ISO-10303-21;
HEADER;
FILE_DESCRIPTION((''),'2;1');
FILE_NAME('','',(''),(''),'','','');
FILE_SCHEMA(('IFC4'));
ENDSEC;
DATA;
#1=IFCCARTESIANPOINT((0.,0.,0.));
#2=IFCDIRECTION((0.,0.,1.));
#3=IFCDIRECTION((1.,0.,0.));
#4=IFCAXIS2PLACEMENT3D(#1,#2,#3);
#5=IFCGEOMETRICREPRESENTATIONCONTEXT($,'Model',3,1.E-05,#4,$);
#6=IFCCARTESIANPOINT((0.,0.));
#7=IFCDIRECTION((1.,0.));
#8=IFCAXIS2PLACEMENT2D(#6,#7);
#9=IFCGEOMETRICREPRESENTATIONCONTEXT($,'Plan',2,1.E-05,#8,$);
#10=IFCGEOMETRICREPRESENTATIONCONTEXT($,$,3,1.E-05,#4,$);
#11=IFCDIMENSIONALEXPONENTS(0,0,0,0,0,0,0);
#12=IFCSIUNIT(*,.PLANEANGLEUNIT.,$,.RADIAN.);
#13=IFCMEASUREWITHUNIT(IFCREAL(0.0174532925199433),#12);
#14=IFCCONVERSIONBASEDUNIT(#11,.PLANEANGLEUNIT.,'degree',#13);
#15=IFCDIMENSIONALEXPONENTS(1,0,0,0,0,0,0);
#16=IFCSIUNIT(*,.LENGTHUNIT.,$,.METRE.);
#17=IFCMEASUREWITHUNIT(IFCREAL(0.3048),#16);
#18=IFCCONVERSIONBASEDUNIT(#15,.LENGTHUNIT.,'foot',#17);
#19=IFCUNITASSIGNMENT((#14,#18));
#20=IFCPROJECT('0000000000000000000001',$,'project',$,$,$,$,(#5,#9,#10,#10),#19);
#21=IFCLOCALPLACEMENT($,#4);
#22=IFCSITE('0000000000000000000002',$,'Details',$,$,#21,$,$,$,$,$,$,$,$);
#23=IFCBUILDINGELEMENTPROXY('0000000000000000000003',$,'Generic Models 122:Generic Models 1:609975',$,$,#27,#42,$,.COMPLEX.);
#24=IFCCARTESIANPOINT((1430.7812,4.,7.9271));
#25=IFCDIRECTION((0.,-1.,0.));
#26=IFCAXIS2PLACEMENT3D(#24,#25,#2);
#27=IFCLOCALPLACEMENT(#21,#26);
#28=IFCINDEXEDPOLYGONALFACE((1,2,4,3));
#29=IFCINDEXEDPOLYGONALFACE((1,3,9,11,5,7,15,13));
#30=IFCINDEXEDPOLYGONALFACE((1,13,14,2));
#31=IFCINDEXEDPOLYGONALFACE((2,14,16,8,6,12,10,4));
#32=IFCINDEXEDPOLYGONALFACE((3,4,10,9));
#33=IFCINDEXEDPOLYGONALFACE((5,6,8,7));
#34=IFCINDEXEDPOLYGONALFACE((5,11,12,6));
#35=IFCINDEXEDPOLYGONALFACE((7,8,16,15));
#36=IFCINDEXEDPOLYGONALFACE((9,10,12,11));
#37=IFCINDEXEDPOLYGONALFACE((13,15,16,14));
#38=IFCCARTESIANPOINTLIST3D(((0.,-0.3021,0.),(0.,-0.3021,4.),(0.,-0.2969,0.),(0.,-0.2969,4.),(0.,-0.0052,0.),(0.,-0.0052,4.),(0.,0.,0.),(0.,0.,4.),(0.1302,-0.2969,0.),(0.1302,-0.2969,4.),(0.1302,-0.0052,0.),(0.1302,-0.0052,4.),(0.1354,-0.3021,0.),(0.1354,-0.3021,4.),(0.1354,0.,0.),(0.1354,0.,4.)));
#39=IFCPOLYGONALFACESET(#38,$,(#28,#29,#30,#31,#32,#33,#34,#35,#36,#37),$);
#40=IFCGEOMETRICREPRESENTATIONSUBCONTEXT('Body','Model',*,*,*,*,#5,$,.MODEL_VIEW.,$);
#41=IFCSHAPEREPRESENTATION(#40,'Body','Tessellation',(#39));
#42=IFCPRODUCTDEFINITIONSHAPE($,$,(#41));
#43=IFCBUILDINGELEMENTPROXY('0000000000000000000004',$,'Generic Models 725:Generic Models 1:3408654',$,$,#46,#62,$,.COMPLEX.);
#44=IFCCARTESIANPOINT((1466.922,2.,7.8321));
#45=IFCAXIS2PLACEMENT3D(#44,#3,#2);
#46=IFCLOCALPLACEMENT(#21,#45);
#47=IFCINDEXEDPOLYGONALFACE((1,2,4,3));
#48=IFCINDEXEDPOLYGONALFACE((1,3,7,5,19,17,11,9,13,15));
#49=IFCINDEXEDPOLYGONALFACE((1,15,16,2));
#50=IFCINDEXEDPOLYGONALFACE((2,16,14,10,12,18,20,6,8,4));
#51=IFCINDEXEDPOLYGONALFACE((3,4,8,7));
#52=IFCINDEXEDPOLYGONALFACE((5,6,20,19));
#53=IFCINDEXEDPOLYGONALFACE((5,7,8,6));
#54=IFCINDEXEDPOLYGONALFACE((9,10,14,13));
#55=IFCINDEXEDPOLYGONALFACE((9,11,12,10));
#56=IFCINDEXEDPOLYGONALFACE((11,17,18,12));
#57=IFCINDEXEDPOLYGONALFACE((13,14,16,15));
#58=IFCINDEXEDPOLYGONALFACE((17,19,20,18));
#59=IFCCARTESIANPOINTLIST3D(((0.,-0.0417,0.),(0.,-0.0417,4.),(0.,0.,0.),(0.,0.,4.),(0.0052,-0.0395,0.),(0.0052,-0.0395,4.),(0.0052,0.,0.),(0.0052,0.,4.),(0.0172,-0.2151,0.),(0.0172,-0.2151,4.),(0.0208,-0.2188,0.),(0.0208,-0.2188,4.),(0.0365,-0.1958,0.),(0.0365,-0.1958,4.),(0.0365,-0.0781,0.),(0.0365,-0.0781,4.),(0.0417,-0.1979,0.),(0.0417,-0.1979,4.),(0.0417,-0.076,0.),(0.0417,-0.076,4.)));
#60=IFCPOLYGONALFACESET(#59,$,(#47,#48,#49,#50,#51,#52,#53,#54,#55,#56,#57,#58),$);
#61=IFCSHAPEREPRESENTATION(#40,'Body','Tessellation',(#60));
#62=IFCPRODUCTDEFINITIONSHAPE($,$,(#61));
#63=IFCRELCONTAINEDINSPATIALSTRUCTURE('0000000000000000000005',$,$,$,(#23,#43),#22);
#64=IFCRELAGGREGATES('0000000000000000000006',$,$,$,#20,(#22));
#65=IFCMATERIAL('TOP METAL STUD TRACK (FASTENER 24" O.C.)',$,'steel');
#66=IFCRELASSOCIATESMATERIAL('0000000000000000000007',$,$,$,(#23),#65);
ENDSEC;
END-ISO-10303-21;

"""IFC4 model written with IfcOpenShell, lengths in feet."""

from ifc_helpers import new_model, entity, si_unit, converted_unit, frame, origin_with_axes, origin_2d_with_axis, place, context, subcontext, project, spatial, line, indexed_curve, outline, extrude, material, element, save


model = new_model("IFC4")

# Units and contexts
model_context = context("Model", 3, precision=1e-05, world=origin_with_axes())
plan_context = context("Plan", 2, precision=1e-05, world=origin_2d_with_axis())
context_of_model = context(None, 3, precision=1e-05, world=origin_with_axes())
body_context = subcontext(model_context, "Body", "Model", "MODEL_VIEW")
ifc_project = project(units=[converted_unit("PLANEANGLEUNIT", "degree", entity("IfcReal", 0.0174532925199433), si_unit("PLANEANGLEUNIT", "RADIAN"), dimensions=[0, 0, 0, 0, 0, 0, 0]), converted_unit("LENGTHUNIT", "foot", entity("IfcReal", 0.3048), si_unit("LENGTHUNIT", "METRE"), dimensions=[1, 0, 0, 0, 0, 0, 0])], contexts=[model_context, plan_context, context_of_model, context_of_model])

# Site
site_placement = place(None, origin_with_axes())
site = spatial("IfcSite", under=ifc_project, at=site_placement, Name="Details")

# Building element proxies
ifc_material_1 = material(Name="TOP METAL STUD TRACK (FASTENER 24\" O.C.)", Category="steel")
proxy_1_placement = place(site_placement, frame((1430.7812, 4.0, 7.9271), z_axis=(0.0, -1.0, 0.0), x_axis=(0.0, 0.0, 1.0)))
element("IfcBuildingElementProxy", 1, at=proxy_1_placement, inside=site, material=ifc_material_1, Name="Generic Models 122:Generic Models 1:609975", PredefinedType="COMPLEX", context=body_context, shape_type="SweptSolid", body=[
    extrude(outline(indexed_curve([(-0.069, -0.151), (0.0664, -0.151), (0.0664, -0.1458), (-0.0638, -0.1458), (-0.0638, 0.1458), (0.0664, 0.1458), (0.0664, 0.151), (-0.069, 0.151)], segments=[line(5, 6), line(6, 7), line(7, 8), line(8, 1), line(1, 2), line(2, 3), line(3, 4), line(4, 5)], self_intersect=False)), frame((0.0664, -0.151, 0.0), z_axis=(0.0, 0.0, -1.0), x_axis=(-1.0, 0.0, 0.0)), (0.0, 0.0, -1.0), 4.0),
])
proxy_2_placement = place(site_placement, frame((1466.922, 2.0, 7.8321), z_axis=(1.0, 0.0, 0.0), x_axis=(0.0, 0.0, 1.0)))
element("IfcBuildingElementProxy", 2, at=proxy_2_placement, inside=site, Name="Generic Models 725:Generic Models 1:3408654", PredefinedType="COMPLEX", context=body_context, shape_type="SweptSolid", body=[
    extrude(outline(indexed_curve([(0.0684, -0.0024), (0.1072, 0.0051), (0.1082, 0.0), (0.0673, -0.0079), (0.0246, 0.021), (-0.0909, -0.0012), (-0.1062, -0.0238), (-0.1105, -0.0209), (-0.094, 0.0035), (0.0258, 0.0266)], segments=[line(6, 5), line(5, 4), line(4, 3), line(3, 2), line(2, 1), line(1, 10), line(10, 9), line(9, 8), line(8, 7), line(7, 6)], self_intersect=False)), frame((0.0205, -0.1063, 0.0), z_axis=(0.0, 0.0, -1.0), x_axis=(-0.189091, 0.98196, 0.0)), (0.0, 0.0, -1.0), 4.0),
])

save(model, "model.ifc")
